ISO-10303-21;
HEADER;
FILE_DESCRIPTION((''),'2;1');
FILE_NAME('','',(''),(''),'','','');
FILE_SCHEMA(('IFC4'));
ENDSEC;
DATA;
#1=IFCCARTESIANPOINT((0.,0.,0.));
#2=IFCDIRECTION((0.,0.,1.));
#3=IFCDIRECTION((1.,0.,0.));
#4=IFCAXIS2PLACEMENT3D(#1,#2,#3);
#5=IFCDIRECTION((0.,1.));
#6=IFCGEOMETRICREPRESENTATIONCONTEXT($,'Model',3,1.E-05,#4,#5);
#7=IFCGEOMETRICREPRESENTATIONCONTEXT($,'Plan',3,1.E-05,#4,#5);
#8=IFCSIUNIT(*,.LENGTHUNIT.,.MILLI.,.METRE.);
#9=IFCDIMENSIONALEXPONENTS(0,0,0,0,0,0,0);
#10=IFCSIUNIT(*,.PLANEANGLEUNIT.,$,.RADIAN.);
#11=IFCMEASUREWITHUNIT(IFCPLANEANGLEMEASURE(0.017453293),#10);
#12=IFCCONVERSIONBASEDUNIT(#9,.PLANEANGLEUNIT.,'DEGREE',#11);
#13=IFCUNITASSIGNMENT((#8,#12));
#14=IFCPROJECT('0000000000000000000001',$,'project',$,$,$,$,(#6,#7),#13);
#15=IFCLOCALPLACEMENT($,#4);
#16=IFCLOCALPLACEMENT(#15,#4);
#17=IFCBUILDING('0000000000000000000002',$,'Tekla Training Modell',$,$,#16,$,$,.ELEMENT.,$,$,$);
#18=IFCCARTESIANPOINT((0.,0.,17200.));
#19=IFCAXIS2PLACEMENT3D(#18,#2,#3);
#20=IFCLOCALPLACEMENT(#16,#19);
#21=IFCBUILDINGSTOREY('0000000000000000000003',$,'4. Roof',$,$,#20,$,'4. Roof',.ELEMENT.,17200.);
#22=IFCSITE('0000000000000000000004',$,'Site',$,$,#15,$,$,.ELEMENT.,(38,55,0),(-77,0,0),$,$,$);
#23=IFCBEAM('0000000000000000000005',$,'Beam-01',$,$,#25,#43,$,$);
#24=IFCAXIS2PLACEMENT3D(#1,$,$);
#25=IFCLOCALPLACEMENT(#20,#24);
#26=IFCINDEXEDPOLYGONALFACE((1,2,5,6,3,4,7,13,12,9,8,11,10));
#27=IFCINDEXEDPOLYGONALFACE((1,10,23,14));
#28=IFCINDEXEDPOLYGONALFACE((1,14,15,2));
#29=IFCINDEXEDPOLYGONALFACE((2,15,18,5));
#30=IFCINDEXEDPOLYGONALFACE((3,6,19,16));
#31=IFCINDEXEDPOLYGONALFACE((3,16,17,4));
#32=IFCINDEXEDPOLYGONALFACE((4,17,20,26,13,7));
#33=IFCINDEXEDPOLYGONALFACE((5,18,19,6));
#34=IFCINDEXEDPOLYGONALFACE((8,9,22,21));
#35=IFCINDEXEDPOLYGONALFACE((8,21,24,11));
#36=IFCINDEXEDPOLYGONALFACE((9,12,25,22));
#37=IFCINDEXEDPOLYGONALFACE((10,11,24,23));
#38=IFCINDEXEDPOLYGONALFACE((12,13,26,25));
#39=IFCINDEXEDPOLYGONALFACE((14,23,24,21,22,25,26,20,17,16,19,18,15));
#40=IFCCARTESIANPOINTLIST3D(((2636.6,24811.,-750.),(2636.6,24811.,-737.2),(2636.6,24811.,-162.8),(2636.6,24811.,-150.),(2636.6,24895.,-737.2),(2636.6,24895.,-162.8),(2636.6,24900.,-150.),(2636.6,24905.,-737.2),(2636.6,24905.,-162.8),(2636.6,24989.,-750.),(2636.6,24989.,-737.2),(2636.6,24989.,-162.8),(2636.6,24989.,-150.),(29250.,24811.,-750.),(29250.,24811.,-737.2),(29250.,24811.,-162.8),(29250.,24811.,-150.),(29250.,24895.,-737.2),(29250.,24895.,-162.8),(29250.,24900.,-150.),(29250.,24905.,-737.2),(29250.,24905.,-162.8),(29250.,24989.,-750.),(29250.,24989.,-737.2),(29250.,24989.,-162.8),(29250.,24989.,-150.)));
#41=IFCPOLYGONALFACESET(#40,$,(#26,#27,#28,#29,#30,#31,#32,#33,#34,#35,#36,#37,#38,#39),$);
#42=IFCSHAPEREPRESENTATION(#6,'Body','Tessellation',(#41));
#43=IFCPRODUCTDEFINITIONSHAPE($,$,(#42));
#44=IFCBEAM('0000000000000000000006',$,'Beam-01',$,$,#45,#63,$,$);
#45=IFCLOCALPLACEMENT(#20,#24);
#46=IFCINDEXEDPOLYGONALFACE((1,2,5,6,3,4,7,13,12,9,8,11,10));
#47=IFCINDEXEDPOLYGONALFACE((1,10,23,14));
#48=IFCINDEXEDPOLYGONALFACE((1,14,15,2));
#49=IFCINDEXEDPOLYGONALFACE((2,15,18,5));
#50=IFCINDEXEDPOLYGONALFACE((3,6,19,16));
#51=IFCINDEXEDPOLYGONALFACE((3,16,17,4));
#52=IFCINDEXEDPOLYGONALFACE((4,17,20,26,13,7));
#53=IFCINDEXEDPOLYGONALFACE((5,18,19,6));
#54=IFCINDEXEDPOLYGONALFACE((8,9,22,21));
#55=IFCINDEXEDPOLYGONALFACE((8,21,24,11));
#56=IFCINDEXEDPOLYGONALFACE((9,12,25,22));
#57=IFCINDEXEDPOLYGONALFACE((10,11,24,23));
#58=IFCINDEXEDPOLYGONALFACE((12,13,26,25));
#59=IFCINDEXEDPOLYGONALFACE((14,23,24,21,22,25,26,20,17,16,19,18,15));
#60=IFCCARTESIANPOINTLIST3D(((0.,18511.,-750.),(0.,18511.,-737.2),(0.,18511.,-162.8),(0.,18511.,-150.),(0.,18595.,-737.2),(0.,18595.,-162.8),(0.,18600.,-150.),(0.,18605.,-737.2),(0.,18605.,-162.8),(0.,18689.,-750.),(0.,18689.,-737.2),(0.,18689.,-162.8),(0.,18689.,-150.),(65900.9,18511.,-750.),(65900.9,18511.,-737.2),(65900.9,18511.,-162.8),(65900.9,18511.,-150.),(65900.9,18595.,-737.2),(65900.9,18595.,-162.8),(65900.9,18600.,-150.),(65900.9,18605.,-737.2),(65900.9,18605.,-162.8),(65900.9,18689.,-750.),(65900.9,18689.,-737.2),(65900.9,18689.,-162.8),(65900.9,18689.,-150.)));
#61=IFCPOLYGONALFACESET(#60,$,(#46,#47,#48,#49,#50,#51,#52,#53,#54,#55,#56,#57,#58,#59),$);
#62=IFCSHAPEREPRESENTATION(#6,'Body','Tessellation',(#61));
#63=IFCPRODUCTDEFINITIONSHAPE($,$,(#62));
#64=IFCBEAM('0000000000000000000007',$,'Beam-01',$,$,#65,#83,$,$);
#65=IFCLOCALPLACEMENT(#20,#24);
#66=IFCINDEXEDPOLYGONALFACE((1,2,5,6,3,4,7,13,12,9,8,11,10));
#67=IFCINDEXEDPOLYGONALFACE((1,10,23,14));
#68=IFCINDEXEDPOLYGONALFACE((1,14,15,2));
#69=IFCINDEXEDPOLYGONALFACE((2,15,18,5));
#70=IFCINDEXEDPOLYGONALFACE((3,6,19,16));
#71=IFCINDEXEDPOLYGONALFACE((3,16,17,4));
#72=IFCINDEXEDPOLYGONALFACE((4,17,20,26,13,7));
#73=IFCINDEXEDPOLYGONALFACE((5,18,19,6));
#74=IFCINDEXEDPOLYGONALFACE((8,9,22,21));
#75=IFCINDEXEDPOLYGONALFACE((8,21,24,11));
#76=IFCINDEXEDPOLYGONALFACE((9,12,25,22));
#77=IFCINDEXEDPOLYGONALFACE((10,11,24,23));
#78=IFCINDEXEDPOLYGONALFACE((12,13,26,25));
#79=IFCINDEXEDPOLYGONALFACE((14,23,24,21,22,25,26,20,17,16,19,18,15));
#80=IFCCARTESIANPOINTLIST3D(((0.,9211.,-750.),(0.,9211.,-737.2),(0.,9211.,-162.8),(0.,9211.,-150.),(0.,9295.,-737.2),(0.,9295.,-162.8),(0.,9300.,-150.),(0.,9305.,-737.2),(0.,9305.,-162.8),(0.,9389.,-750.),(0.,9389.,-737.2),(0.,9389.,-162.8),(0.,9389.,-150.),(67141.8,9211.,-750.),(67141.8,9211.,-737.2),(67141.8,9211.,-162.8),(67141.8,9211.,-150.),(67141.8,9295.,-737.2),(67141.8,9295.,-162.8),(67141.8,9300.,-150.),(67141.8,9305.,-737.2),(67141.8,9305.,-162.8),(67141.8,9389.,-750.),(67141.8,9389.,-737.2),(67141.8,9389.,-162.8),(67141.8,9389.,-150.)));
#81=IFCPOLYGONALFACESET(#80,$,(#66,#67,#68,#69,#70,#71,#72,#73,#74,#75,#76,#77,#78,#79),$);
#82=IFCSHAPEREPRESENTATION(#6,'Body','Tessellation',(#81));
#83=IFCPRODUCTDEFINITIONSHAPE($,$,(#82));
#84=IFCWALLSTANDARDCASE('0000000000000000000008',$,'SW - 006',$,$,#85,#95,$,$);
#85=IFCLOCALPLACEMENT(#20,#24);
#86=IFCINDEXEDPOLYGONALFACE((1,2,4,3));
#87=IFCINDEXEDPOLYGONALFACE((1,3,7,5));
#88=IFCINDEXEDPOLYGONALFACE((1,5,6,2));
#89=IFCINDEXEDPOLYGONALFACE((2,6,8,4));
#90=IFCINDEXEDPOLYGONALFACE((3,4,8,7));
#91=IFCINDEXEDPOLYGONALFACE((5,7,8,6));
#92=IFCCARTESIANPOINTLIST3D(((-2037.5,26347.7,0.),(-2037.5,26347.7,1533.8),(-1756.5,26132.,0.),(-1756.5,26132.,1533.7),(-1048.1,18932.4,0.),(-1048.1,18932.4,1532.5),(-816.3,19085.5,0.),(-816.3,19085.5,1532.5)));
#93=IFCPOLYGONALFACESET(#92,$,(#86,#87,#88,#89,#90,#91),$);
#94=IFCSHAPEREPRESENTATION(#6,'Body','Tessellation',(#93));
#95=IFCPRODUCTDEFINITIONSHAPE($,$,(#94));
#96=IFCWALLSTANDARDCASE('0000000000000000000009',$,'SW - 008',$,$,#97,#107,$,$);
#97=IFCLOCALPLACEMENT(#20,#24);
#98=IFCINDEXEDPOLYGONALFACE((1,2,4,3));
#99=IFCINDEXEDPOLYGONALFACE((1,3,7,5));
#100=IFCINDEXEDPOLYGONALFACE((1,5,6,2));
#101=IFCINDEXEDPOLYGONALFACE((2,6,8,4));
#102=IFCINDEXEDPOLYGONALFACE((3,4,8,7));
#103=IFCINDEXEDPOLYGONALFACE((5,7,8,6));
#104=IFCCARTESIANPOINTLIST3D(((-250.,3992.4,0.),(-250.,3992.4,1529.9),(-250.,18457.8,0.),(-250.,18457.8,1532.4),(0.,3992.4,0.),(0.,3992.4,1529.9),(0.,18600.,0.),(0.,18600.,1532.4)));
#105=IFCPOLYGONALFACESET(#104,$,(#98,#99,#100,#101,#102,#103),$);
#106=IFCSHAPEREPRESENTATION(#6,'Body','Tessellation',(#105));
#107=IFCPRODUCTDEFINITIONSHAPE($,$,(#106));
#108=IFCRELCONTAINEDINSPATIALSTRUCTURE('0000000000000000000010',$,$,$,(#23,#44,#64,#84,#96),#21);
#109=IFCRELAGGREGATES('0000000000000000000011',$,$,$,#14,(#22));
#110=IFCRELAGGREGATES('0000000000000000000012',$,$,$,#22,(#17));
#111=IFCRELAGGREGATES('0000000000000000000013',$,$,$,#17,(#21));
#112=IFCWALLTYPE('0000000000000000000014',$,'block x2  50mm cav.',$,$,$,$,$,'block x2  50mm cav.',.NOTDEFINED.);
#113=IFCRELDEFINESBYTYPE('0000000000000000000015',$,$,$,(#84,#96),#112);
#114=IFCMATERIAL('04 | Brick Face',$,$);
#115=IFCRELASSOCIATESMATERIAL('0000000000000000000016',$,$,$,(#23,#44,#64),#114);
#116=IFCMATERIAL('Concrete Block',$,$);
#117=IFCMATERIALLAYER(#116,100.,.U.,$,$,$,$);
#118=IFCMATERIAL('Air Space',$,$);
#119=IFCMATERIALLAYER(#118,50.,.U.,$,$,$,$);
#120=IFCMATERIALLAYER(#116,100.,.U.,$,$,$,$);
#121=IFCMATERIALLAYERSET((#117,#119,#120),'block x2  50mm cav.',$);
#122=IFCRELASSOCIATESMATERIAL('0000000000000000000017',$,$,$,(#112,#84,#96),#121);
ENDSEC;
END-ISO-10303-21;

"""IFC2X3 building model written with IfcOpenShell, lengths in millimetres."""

from ifc_helpers import new_model, entity, si_unit, converted_unit, direction, frame, origin_with_axes, place, context, project, spatial, polyline, outline, extrude, clip, halfspace, material, layer, layer_set, layer_usage, type_object, element, save


model = new_model("IFC2X3")

# Units and contexts
model_context = context("Model", 3, precision=1e-05, world=origin_with_axes(), true_north=direction((0.0, 1.0)))
plan_context = context("Plan", 3, precision=1e-05, world=origin_with_axes(), true_north=direction((0.0, 1.0)))
ifc_project = project(units=[si_unit("LENGTHUNIT", "METRE", prefix="MILLI"), converted_unit("PLANEANGLEUNIT", "DEGREE", entity("IfcPlaneAngleMeasure", 0.017453293), si_unit("PLANEANGLEUNIT", "RADIAN"), dimensions=[0, 0, 0, 0, 0, 0, 0])], contexts=[model_context, plan_context])

# Site, building, storey
site_placement = place(None, origin_with_axes())
site = spatial("IfcSite", under=ifc_project, at=site_placement, Name="Site", CompositionType="ELEMENT", RefLatitude=(38, 55, 0), RefLongitude=(-77, 0, 0))
building_placement = place(site_placement, origin_with_axes())
building = spatial("IfcBuilding", under=site, at=building_placement, Name="Tekla Training Modell", CompositionType="ELEMENT")
storey_placement = place(building_placement, frame((0.0, 0.0, 17200.0), z_axis=(0.0, 0.0, 1.0), x_axis=(1.0, 0.0, 0.0)))
storey = spatial("IfcBuildingStorey", under=building, at=storey_placement, Name="4. Roof", LongName="4. Roof", CompositionType="ELEMENT", Elevation=17200.0)

# Shared definitions
ifc_material_1 = material(Name="04 | Brick Face")

# Beams
beam_1_placement = place(storey_placement, frame((2636.6, 24900.0, -450.0), z_axis=(0.0, 0.0, 1.0), x_axis=(0.0, -1.0, 0.0)))
element("IfcBeam", 1, at=beam_1_placement, inside=storey, material=ifc_material_1, Name="Beam-01", context=model_context, shape_type="SweptSolid", body=[
    extrude(outline(polyline([(0.0, 300.0), (-89.0, 300.0), (-89.0, 287.2), (-5.0, 287.2), (-5.0, -287.2), (-89.0, -287.2), (-89.0, -300.0), (89.0, -300.0), (89.0, -287.2), (5.0, -287.2), (5.0, 287.2), (89.0, 287.2), (89.0, 300.0), (0.0, 300.0)])), frame((0.0, 26613.4, 0.0), z_axis=(0.0, -1.0, 0.0), x_axis=(1.0, 0.0, 0.0)), (0.0, 0.0, 1.0), 26613.4),
])
beam_2_placement = place(storey_placement, frame((0.0, 18600.0, -450.0), z_axis=(0.0, 0.0, 1.0), x_axis=(0.0, -1.0, 0.0)))
element("IfcBeam", 2, at=beam_2_placement, inside=storey, material=ifc_material_1, Name="Beam-01", context=model_context, shape_type="SweptSolid", body=[
    extrude(outline(polyline([(0.0, 300.0), (-89.0, 300.0), (-89.0, 287.2), (-5.0, 287.2), (-5.0, -287.2), (-89.0, -287.2), (-89.0, -300.0), (89.0, -300.0), (89.0, -287.2), (5.0, -287.2), (5.0, 287.2), (89.0, 287.2), (89.0, 300.0), (0.0, 300.0)])), frame((0.0, 65900.9, 0.0), z_axis=(0.0, -1.0, 0.0), x_axis=(1.0, 0.0, 0.0)), (0.0, 0.0, 1.0), 65900.9),
])
beam_3_placement = place(storey_placement, frame((0.0, 9300.0, -450.0), z_axis=(0.0, 0.0, 1.0), x_axis=(0.0, -1.0, 0.0)))
element("IfcBeam", 3, at=beam_3_placement, inside=storey, material=ifc_material_1, Name="Beam-01", context=model_context, shape_type="SweptSolid", body=[
    extrude(outline(polyline([(0.0, 300.0), (-89.0, 300.0), (-89.0, 287.2), (-5.0, 287.2), (-5.0, -287.2), (-89.0, -287.2), (-89.0, -300.0), (89.0, -300.0), (89.0, -287.2), (5.0, -287.2), (5.0, 287.2), (89.0, 287.2), (89.0, 300.0), (0.0, 300.0)])), frame((0.0, 67141.8, 0.0), z_axis=(0.0, -1.0, 0.0), x_axis=(1.0, 0.0, 0.0)), (0.0, 0.0, 1.0), 67141.8),
])

# Walls
ifc_material_2 = material(Name="Concrete Block")
ifc_layer_1 = layer(ifc_material_2, 100.0, ventilated="UNKNOWN")
ifc_material_3 = material(Name="Air Space")
ifc_layer_2 = layer(ifc_material_3, 50.0, ventilated="UNKNOWN")
ifc_layer_3 = layer(ifc_material_2, 100.0, ventilated="UNKNOWN")
ifc_layer_set = layer_set([ifc_layer_1, ifc_layer_2, ifc_layer_3], Name="block x2  50mm cav.")
wall_type = type_object("IfcWallType", Name="block x2  50mm cav.", ElementType="block x2  50mm cav.", PredefinedType="NOTDEFINED", material=ifc_layer_set)
ifc_layer_usage_1 = layer_usage(ifc_layer_set, "AXIS2", "NEGATIVE", 0.0)
wall_1_placement = place(storey_placement, frame((-1756.5, 26132.0, 0.0), z_axis=(0.0, 0.0, 1.0), x_axis=(0.132257, -0.991215, 0.0)))
element("IfcWallStandardCase", 4, at=wall_1_placement, inside=storey, type_object=wall_type, material=ifc_layer_usage_1, Name="SW - 006", context=model_context, shape_type="Clipping", body=[
    clip(clip(extrude(outline(polyline([(-251.0, -250.0), (7230.0, -250.0), (7109.0, 0.0), (0.0, 0.0), (-251.0, -250.0)])), origin_with_axes(), (0.0, 0.0, 1.0), 3302.0), halfspace(frame((0.3, 0.0, 1533.7), z_axis=(-0.000173, 0.000023, -1.0), x_axis=(0.0, 1.0, 0.000023)), True)), halfspace(frame((0.3, 0.0, 1533.7), z_axis=(-0.000173, 0.000023, -1.0), x_axis=(0.0, 1.0, 0.000023)), True)),
])
ifc_layer_usage_2 = layer_usage(ifc_layer_set, "AXIS2", "NEGATIVE", 0.0)
wall_2_placement = place(storey_placement, frame((0.0, 18600.0, 0.0), z_axis=(0.0, 0.0, 1.0), x_axis=(0.0, -1.0, 0.0)))
element("IfcWallStandardCase", 5, at=wall_2_placement, inside=storey, type_object=wall_type, material=ifc_layer_usage_2, Name="SW - 008", context=model_context, shape_type="Clipping", body=[
    clip(clip(clip(clip(extrude(outline(polyline([(142.2, -250.0), (14607.6, -250.0), (14607.6, 0.0), (0.0, 0.0), (142.2, -250.0)])), origin_with_axes(), (0.0, 0.0, 1.0), 3302.0), halfspace(frame((0.3, 0.0, 1532.4), z_axis=(-0.000175, 0.0, -1.0), x_axis=(0.0, 1.0, 0.0)), True)), halfspace(frame((0.3, 0.0, 1532.4), z_axis=(-0.000175, 0.0, -1.0), x_axis=(0.0, 1.0, 0.0)), True)), halfspace(frame((0.3, 0.0, 1532.4), z_axis=(-0.000175, 0.0, -1.0), x_axis=(0.0, 1.0, 0.0)), True)), halfspace(frame((0.3, 0.0, 1532.4), z_axis=(-0.000175, 0.0, -1.0), x_axis=(0.0, 1.0, 0.0)), True)),
])

save(model, "model.ifc")
